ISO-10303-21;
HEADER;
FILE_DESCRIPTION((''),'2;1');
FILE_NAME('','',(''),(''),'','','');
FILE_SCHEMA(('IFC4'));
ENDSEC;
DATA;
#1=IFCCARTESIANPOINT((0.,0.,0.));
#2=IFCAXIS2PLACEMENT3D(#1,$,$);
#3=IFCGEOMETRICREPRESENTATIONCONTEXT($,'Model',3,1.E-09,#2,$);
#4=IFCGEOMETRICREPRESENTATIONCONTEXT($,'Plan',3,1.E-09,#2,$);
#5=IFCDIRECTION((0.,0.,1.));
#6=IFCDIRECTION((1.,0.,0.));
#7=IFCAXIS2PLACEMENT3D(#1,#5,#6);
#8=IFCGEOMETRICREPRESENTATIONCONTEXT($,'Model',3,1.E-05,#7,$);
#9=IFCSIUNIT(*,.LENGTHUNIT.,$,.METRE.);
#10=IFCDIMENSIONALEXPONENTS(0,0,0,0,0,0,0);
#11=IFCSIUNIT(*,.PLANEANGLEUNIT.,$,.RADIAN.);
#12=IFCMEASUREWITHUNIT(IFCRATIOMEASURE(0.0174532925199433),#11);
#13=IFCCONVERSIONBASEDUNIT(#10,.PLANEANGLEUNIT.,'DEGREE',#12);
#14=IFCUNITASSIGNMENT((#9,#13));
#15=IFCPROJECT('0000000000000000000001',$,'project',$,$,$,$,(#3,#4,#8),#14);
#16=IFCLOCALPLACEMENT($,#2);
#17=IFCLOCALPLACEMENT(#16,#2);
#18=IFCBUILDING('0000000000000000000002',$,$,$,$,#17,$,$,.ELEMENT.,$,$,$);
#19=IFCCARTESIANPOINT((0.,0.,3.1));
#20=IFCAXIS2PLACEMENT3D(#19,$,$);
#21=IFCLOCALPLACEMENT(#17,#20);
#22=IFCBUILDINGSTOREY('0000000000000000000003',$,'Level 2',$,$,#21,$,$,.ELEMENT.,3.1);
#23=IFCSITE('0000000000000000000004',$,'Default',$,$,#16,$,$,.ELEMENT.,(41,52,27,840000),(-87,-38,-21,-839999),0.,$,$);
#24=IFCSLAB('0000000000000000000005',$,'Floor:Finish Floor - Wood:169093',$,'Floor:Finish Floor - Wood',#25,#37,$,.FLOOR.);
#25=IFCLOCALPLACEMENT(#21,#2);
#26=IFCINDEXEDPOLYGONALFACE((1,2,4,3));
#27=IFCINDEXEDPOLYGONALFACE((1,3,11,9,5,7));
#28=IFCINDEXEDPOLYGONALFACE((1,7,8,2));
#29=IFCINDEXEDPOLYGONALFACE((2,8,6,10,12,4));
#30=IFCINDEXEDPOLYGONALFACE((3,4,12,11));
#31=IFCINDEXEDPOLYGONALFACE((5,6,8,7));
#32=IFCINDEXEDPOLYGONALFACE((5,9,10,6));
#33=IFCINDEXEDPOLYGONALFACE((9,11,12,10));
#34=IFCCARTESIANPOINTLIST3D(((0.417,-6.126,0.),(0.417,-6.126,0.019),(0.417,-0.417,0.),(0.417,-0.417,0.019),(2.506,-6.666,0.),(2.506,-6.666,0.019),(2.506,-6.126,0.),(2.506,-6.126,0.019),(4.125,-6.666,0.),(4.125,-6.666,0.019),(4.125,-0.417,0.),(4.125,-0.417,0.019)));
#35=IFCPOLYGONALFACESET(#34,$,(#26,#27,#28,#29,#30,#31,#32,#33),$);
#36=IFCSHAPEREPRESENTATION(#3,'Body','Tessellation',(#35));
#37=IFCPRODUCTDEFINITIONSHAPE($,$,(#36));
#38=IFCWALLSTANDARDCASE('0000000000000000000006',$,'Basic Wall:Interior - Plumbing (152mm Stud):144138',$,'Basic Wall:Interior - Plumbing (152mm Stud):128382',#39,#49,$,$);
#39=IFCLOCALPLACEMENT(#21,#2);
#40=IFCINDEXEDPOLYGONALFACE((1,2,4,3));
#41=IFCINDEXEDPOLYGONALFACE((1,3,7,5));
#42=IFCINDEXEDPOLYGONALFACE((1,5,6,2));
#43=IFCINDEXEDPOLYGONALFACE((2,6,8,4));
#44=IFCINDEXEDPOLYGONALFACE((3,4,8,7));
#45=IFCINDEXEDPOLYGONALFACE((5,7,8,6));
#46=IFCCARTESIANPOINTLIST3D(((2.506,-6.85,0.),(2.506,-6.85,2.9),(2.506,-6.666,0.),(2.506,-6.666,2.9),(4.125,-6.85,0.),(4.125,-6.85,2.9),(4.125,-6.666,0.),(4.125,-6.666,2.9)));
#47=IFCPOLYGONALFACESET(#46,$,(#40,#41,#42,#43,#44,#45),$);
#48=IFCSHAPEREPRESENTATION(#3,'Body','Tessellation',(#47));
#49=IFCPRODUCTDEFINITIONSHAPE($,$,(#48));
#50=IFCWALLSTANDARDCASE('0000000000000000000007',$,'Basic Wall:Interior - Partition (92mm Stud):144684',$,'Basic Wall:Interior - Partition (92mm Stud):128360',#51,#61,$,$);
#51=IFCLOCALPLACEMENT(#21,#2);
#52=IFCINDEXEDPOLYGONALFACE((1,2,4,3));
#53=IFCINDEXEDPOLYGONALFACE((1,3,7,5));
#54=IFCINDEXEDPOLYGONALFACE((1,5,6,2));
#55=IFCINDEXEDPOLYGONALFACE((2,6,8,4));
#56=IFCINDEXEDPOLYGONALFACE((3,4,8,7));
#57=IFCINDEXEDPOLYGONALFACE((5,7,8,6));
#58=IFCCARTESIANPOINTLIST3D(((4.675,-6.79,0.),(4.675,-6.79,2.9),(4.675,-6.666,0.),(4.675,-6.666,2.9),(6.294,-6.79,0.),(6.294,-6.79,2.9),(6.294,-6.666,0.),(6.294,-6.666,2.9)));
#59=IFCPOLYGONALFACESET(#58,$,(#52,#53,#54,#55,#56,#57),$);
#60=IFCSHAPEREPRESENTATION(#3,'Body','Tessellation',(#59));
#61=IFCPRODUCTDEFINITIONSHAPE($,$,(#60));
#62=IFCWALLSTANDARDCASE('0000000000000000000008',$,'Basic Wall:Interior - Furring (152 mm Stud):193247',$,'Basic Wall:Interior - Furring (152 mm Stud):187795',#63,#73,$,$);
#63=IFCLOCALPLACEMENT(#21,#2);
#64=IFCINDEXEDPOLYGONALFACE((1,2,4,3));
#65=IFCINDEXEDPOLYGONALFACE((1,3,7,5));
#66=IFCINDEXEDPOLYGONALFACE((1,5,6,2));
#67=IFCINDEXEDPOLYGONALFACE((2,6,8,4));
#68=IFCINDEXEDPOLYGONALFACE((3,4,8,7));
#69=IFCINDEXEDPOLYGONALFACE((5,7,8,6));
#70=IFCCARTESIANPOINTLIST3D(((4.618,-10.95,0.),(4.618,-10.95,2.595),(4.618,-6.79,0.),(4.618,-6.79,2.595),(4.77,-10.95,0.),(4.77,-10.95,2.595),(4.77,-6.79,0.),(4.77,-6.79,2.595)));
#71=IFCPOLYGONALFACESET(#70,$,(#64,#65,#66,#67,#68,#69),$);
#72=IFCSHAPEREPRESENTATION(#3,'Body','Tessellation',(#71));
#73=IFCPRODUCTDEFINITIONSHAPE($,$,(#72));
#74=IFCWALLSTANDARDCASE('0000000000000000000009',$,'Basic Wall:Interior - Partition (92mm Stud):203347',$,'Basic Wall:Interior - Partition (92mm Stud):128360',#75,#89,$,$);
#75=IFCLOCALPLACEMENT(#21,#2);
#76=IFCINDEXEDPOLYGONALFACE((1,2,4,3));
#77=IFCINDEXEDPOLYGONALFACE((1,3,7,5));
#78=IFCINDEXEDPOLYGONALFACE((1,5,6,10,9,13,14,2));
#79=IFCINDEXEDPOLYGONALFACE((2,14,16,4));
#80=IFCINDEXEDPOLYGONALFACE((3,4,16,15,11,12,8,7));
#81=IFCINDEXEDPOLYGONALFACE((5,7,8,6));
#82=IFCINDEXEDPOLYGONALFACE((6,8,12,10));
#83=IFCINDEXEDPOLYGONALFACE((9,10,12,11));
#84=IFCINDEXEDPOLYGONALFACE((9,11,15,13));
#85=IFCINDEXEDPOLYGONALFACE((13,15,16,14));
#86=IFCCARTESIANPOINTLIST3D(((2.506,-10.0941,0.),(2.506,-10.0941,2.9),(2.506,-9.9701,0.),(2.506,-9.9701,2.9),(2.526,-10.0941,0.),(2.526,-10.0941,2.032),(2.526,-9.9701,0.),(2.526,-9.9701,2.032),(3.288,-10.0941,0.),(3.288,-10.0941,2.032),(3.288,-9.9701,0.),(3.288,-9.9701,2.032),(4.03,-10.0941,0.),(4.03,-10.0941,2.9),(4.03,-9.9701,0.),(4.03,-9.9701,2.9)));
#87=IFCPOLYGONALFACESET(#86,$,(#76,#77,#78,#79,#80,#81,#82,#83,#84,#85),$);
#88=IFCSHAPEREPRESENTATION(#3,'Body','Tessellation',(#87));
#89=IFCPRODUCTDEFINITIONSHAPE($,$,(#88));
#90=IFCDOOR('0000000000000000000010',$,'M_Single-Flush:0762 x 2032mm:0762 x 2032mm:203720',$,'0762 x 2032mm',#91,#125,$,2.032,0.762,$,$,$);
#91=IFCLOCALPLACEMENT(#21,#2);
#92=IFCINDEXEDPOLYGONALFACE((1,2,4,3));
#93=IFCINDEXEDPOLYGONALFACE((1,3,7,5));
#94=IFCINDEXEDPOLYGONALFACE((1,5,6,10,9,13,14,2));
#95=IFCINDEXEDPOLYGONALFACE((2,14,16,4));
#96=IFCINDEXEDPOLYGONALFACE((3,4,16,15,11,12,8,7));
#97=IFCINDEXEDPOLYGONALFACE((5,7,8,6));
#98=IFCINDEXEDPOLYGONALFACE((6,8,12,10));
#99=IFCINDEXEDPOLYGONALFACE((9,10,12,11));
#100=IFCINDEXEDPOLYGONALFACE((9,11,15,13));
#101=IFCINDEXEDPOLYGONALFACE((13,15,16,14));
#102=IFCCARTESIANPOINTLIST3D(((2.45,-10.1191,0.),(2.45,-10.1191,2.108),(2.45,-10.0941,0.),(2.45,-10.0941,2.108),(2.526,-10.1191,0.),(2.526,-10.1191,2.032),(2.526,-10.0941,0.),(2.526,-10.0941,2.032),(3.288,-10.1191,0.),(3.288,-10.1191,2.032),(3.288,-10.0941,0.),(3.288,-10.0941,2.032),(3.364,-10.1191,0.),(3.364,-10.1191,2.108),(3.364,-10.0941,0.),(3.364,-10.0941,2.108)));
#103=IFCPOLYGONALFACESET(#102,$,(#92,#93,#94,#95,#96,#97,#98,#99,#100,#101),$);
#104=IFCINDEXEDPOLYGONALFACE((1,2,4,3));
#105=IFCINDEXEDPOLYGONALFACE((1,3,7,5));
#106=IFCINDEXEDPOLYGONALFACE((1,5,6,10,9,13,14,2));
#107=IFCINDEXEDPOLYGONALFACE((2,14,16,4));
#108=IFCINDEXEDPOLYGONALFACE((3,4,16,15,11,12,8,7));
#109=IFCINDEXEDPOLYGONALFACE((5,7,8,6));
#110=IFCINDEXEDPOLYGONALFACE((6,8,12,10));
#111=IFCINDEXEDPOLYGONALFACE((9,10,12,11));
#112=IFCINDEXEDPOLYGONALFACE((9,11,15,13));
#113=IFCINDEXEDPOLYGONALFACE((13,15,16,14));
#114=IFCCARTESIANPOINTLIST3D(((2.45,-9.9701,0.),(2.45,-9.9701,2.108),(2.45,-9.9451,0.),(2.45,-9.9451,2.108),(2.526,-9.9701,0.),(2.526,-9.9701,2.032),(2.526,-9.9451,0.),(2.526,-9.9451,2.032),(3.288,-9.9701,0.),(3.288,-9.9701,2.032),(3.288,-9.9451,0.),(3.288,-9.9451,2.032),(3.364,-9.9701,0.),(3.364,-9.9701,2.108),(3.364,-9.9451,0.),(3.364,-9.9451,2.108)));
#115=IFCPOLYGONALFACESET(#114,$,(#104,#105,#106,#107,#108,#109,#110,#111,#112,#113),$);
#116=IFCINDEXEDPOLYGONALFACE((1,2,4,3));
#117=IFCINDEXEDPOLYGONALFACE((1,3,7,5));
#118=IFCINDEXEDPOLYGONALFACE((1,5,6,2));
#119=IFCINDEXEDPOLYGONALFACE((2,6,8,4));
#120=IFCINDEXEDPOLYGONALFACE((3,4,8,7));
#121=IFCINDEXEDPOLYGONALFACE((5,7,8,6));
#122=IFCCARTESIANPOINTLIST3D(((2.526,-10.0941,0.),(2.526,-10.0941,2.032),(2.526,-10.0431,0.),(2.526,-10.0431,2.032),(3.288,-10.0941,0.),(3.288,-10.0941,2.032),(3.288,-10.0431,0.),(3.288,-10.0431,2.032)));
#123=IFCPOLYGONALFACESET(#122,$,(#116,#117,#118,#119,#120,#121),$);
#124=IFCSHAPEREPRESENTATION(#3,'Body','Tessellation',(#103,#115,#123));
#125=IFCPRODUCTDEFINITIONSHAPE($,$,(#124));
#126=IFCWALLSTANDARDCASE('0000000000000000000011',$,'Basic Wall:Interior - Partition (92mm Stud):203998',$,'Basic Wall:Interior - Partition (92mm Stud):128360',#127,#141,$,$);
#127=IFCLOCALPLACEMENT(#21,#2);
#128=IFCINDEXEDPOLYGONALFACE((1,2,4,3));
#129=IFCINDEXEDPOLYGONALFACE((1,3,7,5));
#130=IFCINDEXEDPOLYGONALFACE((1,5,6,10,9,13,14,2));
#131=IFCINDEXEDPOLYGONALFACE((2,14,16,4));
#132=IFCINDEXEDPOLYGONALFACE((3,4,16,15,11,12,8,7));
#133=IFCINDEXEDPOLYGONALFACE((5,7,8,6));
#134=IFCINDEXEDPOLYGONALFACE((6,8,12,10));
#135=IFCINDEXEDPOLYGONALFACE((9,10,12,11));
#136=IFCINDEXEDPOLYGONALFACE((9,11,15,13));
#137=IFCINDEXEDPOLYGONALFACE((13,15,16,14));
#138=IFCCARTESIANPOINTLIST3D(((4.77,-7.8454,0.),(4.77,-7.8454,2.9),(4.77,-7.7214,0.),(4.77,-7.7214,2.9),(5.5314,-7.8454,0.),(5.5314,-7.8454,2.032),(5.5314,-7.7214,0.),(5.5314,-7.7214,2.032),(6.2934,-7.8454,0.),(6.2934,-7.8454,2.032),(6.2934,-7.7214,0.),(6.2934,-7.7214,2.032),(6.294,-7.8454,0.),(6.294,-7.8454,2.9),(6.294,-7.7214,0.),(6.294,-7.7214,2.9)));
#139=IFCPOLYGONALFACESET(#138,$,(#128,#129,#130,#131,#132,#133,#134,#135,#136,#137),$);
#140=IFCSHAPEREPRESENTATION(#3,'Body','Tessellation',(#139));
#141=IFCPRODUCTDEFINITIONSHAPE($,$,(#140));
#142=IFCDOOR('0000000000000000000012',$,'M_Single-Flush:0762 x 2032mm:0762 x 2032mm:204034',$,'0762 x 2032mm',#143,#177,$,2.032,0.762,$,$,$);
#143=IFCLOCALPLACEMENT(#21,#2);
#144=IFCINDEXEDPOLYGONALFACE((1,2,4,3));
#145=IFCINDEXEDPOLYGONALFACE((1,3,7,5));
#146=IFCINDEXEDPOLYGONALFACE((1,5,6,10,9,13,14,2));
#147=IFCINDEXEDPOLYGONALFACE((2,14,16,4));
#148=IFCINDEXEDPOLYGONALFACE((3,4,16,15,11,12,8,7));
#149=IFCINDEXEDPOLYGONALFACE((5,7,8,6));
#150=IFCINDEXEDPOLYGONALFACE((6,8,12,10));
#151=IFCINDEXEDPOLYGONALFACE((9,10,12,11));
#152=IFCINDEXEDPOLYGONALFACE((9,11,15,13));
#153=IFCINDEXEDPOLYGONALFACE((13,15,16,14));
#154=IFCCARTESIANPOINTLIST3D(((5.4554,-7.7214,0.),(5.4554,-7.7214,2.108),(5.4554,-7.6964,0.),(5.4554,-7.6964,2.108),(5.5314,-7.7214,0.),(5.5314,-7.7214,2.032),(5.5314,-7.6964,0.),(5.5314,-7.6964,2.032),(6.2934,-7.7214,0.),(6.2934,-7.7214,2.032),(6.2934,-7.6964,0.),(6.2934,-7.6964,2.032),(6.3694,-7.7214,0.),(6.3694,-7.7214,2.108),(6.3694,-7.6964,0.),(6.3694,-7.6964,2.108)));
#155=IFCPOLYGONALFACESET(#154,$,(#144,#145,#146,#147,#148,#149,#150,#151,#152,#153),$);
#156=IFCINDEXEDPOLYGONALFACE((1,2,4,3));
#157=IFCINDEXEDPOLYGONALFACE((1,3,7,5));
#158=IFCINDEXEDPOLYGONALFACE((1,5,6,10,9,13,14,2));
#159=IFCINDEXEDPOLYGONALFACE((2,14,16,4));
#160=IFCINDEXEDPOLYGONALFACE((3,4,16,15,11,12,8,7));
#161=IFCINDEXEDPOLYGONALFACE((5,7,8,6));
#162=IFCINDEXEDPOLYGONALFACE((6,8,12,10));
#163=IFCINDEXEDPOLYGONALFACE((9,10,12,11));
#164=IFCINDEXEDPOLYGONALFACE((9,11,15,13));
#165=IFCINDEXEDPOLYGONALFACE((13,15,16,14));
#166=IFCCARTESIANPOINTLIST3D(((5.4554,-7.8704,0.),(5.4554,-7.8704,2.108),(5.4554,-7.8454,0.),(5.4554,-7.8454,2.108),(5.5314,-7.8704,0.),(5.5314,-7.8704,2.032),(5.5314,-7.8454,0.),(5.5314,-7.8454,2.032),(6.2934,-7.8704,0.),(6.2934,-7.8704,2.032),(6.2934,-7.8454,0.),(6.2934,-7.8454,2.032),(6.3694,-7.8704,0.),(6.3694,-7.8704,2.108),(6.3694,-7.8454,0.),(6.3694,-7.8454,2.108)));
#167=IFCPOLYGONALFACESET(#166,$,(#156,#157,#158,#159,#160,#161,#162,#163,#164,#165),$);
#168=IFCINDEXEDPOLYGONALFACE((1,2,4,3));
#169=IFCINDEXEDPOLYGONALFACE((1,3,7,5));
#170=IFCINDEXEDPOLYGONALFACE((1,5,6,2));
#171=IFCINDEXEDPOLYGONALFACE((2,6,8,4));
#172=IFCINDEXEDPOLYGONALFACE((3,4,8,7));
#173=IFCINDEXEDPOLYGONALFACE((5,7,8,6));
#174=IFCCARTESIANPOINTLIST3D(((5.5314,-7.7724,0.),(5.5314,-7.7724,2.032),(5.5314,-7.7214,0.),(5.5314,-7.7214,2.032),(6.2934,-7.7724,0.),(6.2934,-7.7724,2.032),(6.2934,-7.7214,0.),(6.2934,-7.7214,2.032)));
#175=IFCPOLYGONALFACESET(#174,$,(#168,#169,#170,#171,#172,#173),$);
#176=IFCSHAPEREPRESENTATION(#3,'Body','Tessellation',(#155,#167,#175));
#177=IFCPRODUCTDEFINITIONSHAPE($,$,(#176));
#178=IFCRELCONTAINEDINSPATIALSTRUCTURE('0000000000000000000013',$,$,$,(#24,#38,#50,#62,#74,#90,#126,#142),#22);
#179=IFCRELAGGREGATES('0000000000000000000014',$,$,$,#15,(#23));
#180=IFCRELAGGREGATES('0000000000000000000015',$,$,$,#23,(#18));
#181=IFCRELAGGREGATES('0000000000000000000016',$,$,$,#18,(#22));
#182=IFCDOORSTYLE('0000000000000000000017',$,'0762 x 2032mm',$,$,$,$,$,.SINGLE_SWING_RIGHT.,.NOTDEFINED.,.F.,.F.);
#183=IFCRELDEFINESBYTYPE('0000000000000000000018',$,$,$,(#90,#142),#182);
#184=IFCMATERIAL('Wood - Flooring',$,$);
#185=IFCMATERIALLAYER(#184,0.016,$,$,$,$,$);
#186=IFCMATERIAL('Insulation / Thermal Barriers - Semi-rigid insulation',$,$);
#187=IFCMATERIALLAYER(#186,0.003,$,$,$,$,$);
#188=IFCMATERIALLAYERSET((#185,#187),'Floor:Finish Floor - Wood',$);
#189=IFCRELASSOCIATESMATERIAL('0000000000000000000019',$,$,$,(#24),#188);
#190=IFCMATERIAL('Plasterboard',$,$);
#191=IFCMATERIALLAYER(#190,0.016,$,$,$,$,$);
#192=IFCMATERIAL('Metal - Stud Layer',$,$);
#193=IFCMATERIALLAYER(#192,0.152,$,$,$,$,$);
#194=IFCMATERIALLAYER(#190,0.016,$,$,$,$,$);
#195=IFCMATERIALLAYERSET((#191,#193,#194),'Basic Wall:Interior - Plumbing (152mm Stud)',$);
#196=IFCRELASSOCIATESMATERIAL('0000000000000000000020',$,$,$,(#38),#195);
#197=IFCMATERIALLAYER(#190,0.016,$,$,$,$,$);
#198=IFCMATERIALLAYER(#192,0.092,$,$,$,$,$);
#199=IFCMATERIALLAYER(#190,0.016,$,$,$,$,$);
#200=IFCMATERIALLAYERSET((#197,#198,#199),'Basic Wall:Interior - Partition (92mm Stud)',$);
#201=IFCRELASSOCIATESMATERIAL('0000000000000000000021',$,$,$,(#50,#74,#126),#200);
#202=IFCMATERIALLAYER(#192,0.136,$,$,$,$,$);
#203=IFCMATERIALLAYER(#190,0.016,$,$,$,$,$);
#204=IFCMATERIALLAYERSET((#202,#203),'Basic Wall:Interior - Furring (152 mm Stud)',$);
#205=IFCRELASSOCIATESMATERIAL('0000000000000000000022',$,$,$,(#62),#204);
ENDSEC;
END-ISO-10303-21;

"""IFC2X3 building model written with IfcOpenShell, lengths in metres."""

from ifc_helpers import new_model, entity, si_unit, converted_unit, frame, frame_2d, origin, origin_with_axes, origin_2d_with_axis, place, context, project, spatial, polyline, rectangle, outline, extrude, source, transform, mapped, material, layer, layer_set, layer_usage, type_object, type_shapes, element, fill, save


model = new_model("IFC2X3")

# Units and contexts
model_context_1 = context("Model", 3, precision=1e-09, world=origin())
plan_context = context("Plan", 3, precision=1e-09, world=origin())
model_context_2 = context("Model", 3, precision=1e-05, world=origin_with_axes())
ifc_project = project(units=[si_unit("LENGTHUNIT", "METRE"), converted_unit("PLANEANGLEUNIT", "DEGREE", entity("IfcRatioMeasure", 0.0174532925199433), si_unit("PLANEANGLEUNIT", "RADIAN"), dimensions=[0, 0, 0, 0, 0, 0, 0])], contexts=[model_context_1, plan_context, model_context_2])

# Site, building, storey
site_placement = place(None, origin())
site = spatial("IfcSite", under=ifc_project, at=site_placement, Name="Default", CompositionType="ELEMENT", RefLatitude=(41, 52, 27, 840000), RefLongitude=(-87, -38, -21, -839999), RefElevation=0.0)
building_placement = place(site_placement, origin())
building = spatial("IfcBuilding", under=site, at=building_placement, CompositionType="ELEMENT")
storey_placement = place(building_placement, frame((0.0, 0.0, 3.1)))
storey = spatial("IfcBuildingStorey", under=building, at=storey_placement, Name="Level 2", CompositionType="ELEMENT", Elevation=3.1)

# Slab
ifc_material_1 = material(Name="Wood - Flooring")
ifc_layer_1 = layer(ifc_material_1, 0.016)
ifc_material_2 = material(Name="Insulation / Thermal Barriers - Semi-rigid insulation")
ifc_layer_2 = layer(ifc_material_2, 0.003)
ifc_layer_set_1 = layer_set([ifc_layer_1, ifc_layer_2], Name="Floor:Finish Floor - Wood")
ifc_layer_usage_1 = layer_usage(ifc_layer_set_1, "AXIS3", "POSITIVE", 0.0)
slab_placement = place(storey_placement, frame((0.417, -6.666, 0.0)))
element("IfcSlab", 1, at=slab_placement, inside=storey, material=ifc_layer_usage_1, Name="Floor:Finish Floor - Wood:169093", ObjectType="Floor:Finish Floor - Wood", PredefinedType="FLOOR", context=model_context_1, shape_type="SweptSolid", body=[
    extrude(outline(polyline([(1.854, 3.1245), (-1.854, 3.1245), (-1.854, -3.1245), (-0.235, -3.1245), (-0.235, -2.5845), (1.854, -2.5845), (1.854, 3.1245)])), frame((1.854, 3.1245, 0.019), z_axis=(0.0, 0.0, -1.0), x_axis=(-1.0, 0.0, 0.0)), (0.0, 0.0, 1.0), 0.019),
])

# Walls
ifc_material_3 = material(Name="Plasterboard")
ifc_layer_3 = layer(ifc_material_3, 0.016)
ifc_material_4 = material(Name="Metal - Stud Layer")
ifc_layer_4 = layer(ifc_material_4, 0.152)
ifc_layer_5 = layer(ifc_material_3, 0.016)
ifc_layer_set_2 = layer_set([ifc_layer_3, ifc_layer_4, ifc_layer_5], Name="Basic Wall:Interior - Plumbing (152mm Stud)")
ifc_layer_usage_2 = layer_usage(ifc_layer_set_2, "AXIS2", "NEGATIVE", 0.092)
wall_1_placement = place(storey_placement, frame((2.506, -6.758, 0.0)))
element("IfcWallStandardCase", 2, at=wall_1_placement, inside=storey, material=ifc_layer_usage_2, Name="Basic Wall:Interior - Plumbing (152mm Stud):144138", ObjectType="Basic Wall:Interior - Plumbing (152mm Stud):128382", context=model_context_1, shape_type="SweptSolid", body=[
    extrude(rectangle(XDim=1.619, YDim=0.184, at=frame_2d((0.8095, 0.0), x_axis=(-1.0, 0.0))), origin(), (0.0, 0.0, 1.0), 2.9),
])
ifc_layer_6 = layer(ifc_material_3, 0.016)
ifc_layer_7 = layer(ifc_material_4, 0.092)
ifc_layer_8 = layer(ifc_material_3, 0.016)
ifc_layer_set_3 = layer_set([ifc_layer_6, ifc_layer_7, ifc_layer_8], Name="Basic Wall:Interior - Partition (92mm Stud)")
ifc_layer_usage_3 = layer_usage(ifc_layer_set_3, "AXIS2", "NEGATIVE", 0.062)
wall_2_placement = place(storey_placement, frame((4.675, -6.728, 0.0)))
element("IfcWallStandardCase", 3, at=wall_2_placement, inside=storey, material=ifc_layer_usage_3, Name="Basic Wall:Interior - Partition (92mm Stud):144684", ObjectType="Basic Wall:Interior - Partition (92mm Stud):128360", context=model_context_1, shape_type="SweptSolid", body=[
    extrude(rectangle(XDim=1.619, YDim=0.124, at=frame_2d((0.8095, 0.0), x_axis=(-1.0, 0.0))), origin(), (0.0, 0.0, 1.0), 2.9),
])
ifc_layer_9 = layer(ifc_material_4, 0.136)
ifc_layer_10 = layer(ifc_material_3, 0.016)
ifc_layer_set_4 = layer_set([ifc_layer_9, ifc_layer_10], Name="Basic Wall:Interior - Furring (152 mm Stud)")
ifc_layer_usage_4 = layer_usage(ifc_layer_set_4, "AXIS2", "POSITIVE", -0.076)
wall_3_placement = place(storey_placement, frame((4.694, -6.79, 0.0), z_axis=(0.0, 0.0, 1.0), x_axis=(0.0, -1.0, 0.0)))
element("IfcWallStandardCase", 4, at=wall_3_placement, inside=storey, material=ifc_layer_usage_4, Name="Basic Wall:Interior - Furring (152 mm Stud):193247", ObjectType="Basic Wall:Interior - Furring (152 mm Stud):187795", context=model_context_1, shape_type="SweptSolid", body=[
    extrude(rectangle(XDim=4.16, YDim=0.152, at=frame_2d((2.08, 0.0), x_axis=(-1.0, 0.0))), origin(), (0.0, 0.0, 1.0), 2.595),
])

# Walls, openings, doors
ifc_layer_usage_5 = layer_usage(ifc_layer_set_3, "AXIS2", "NEGATIVE", 0.062)
wall_4_placement = place(storey_placement, frame((4.03, -10.0321, 0.0), z_axis=(0.0, 0.0, 1.0), x_axis=(-1.0, 0.0, 0.0)))
wall_4 = element("IfcWallStandardCase", 5, at=wall_4_placement, inside=storey, material=ifc_layer_usage_5, Name="Basic Wall:Interior - Partition (92mm Stud):203347", ObjectType="Basic Wall:Interior - Partition (92mm Stud):128360", context=model_context_1, shape_type="SweptSolid", body=[
    extrude(rectangle(XDim=1.524, YDim=0.124, at=frame_2d((0.762, 0.0), x_axis=(-1.0, 0.0))), origin(), (0.0, 0.0, 1.0), 2.9),
])
opening_1_placement = place(wall_4_placement, frame((0.742, -0.062, 0.0)))
opening_1 = element("IfcOpeningElement", 6, at=opening_1_placement, cuts=wall_4, ObjectType="Opening", context=model_context_1, shape_type="SweptSolid", body=[
    extrude(rectangle(XDim=0.762, YDim=2.032, at=frame_2d((1.016, 0.381), x_axis=(0.0, 1.0))), frame((0.0, 0.0, 0.0), z_axis=(0.0, 1.0, 0.0), x_axis=(0.0, 0.0, 1.0)), (0.0, 0.0, 1.0), 0.124),
])
door_style = type_object("IfcDoorStyle", Name="0762 x 2032mm", ConstructionType="NOTDEFINED", OperationType="SINGLE_SWING_RIGHT", ParameterTakesPrecedence=False, Sizeable=False)
shared_shape = source(origin(), model_context_1, "Body", "SweptSolid", [
    extrude(outline(polyline([(-0.457, -1.073), (0.457, -1.073), (0.457, 1.035), (0.381, 1.035), (0.381, -0.997), (-0.381, -0.997), (-0.381, 1.035), (-0.457, 1.035), (-0.457, -1.073)])), frame((0.381, 0.124, 1.035), z_axis=(0.0, 1.0, 0.0), x_axis=(1.0, 0.0, 0.0)), (0.0, 0.0, 1.0), 0.025),
    extrude(outline(polyline([(-1.073, -0.457), (1.035, -0.457), (1.035, -0.381), (-0.997, -0.381), (-0.997, 0.381), (1.035, 0.381), (1.035, 0.457), (-1.073, 0.457), (-1.073, -0.457)])), frame((0.381, -0.025, 1.035), z_axis=(0.0, 1.0, 0.0), x_axis=(0.0, 0.0, -1.0)), (0.0, 0.0, 1.0), 0.025),
    extrude(rectangle(XDim=0.051, YDim=0.762, at=origin_2d_with_axis()), frame((0.381, 0.0985, 0.0), z_axis=(0.0, 0.0, 1.0), x_axis=(0.0, 1.0, 0.0)), (0.0, 0.0, 1.0), 2.032),
])
type_shapes(door_style, [shared_shape])
door_1_placement = place(opening_1_placement, origin())
door_1 = element("IfcDoor", 7, at=door_1_placement, inside=storey, type_object=door_style, Name="M_Single-Flush:0762 x 2032mm:0762 x 2032mm:203720", ObjectType="0762 x 2032mm", OverallHeight=2.032, OverallWidth=0.762, context=model_context_1, shape_type="MappedRepresentation", body=[
    mapped(shared_shape, transform((0.0, 0.0, 0.0), scale=1.0)),
])
fill(opening_1, door_1)
ifc_layer_usage_6 = layer_usage(ifc_layer_set_3, "AXIS2", "POSITIVE", -0.062)
wall_5_placement = place(storey_placement, frame((4.77, -7.7834, 0.0)))
wall_5 = element("IfcWallStandardCase", 8, at=wall_5_placement, inside=storey, material=ifc_layer_usage_6, Name="Basic Wall:Interior - Partition (92mm Stud):203998", ObjectType="Basic Wall:Interior - Partition (92mm Stud):128360", context=model_context_1, shape_type="SweptSolid", body=[
    extrude(rectangle(XDim=1.524, YDim=0.124, at=frame_2d((0.762, 0.0), x_axis=(-1.0, 0.0))), origin(), (0.0, 0.0, 1.0), 2.9),
])
opening_2_placement = place(wall_5_placement, frame((0.7614, -0.062, 0.0)))
opening_2 = element("IfcOpeningElement", 9, at=opening_2_placement, cuts=wall_5, ObjectType="Opening", context=model_context_1, shape_type="SweptSolid", body=[
    extrude(rectangle(XDim=0.762, YDim=2.032, at=frame_2d((1.016, 0.381), x_axis=(0.0, 1.0))), frame((0.0, 0.0, 0.0), z_axis=(0.0, 1.0, 0.0), x_axis=(0.0, 0.0, 1.0)), (0.0, 0.0, 1.0), 0.124),
])
door_2_placement = place(opening_2_placement, origin())
door_2 = element("IfcDoor", 10, at=door_2_placement, inside=storey, type_object=door_style, Name="M_Single-Flush:0762 x 2032mm:0762 x 2032mm:204034", ObjectType="0762 x 2032mm", OverallHeight=2.032, OverallWidth=0.762, context=model_context_1, shape_type="MappedRepresentation", body=[
    mapped(shared_shape, transform((0.0, 0.0, 0.0), scale=1.0)),
])
fill(opening_2, door_2)

save(model, "model.ifc")
